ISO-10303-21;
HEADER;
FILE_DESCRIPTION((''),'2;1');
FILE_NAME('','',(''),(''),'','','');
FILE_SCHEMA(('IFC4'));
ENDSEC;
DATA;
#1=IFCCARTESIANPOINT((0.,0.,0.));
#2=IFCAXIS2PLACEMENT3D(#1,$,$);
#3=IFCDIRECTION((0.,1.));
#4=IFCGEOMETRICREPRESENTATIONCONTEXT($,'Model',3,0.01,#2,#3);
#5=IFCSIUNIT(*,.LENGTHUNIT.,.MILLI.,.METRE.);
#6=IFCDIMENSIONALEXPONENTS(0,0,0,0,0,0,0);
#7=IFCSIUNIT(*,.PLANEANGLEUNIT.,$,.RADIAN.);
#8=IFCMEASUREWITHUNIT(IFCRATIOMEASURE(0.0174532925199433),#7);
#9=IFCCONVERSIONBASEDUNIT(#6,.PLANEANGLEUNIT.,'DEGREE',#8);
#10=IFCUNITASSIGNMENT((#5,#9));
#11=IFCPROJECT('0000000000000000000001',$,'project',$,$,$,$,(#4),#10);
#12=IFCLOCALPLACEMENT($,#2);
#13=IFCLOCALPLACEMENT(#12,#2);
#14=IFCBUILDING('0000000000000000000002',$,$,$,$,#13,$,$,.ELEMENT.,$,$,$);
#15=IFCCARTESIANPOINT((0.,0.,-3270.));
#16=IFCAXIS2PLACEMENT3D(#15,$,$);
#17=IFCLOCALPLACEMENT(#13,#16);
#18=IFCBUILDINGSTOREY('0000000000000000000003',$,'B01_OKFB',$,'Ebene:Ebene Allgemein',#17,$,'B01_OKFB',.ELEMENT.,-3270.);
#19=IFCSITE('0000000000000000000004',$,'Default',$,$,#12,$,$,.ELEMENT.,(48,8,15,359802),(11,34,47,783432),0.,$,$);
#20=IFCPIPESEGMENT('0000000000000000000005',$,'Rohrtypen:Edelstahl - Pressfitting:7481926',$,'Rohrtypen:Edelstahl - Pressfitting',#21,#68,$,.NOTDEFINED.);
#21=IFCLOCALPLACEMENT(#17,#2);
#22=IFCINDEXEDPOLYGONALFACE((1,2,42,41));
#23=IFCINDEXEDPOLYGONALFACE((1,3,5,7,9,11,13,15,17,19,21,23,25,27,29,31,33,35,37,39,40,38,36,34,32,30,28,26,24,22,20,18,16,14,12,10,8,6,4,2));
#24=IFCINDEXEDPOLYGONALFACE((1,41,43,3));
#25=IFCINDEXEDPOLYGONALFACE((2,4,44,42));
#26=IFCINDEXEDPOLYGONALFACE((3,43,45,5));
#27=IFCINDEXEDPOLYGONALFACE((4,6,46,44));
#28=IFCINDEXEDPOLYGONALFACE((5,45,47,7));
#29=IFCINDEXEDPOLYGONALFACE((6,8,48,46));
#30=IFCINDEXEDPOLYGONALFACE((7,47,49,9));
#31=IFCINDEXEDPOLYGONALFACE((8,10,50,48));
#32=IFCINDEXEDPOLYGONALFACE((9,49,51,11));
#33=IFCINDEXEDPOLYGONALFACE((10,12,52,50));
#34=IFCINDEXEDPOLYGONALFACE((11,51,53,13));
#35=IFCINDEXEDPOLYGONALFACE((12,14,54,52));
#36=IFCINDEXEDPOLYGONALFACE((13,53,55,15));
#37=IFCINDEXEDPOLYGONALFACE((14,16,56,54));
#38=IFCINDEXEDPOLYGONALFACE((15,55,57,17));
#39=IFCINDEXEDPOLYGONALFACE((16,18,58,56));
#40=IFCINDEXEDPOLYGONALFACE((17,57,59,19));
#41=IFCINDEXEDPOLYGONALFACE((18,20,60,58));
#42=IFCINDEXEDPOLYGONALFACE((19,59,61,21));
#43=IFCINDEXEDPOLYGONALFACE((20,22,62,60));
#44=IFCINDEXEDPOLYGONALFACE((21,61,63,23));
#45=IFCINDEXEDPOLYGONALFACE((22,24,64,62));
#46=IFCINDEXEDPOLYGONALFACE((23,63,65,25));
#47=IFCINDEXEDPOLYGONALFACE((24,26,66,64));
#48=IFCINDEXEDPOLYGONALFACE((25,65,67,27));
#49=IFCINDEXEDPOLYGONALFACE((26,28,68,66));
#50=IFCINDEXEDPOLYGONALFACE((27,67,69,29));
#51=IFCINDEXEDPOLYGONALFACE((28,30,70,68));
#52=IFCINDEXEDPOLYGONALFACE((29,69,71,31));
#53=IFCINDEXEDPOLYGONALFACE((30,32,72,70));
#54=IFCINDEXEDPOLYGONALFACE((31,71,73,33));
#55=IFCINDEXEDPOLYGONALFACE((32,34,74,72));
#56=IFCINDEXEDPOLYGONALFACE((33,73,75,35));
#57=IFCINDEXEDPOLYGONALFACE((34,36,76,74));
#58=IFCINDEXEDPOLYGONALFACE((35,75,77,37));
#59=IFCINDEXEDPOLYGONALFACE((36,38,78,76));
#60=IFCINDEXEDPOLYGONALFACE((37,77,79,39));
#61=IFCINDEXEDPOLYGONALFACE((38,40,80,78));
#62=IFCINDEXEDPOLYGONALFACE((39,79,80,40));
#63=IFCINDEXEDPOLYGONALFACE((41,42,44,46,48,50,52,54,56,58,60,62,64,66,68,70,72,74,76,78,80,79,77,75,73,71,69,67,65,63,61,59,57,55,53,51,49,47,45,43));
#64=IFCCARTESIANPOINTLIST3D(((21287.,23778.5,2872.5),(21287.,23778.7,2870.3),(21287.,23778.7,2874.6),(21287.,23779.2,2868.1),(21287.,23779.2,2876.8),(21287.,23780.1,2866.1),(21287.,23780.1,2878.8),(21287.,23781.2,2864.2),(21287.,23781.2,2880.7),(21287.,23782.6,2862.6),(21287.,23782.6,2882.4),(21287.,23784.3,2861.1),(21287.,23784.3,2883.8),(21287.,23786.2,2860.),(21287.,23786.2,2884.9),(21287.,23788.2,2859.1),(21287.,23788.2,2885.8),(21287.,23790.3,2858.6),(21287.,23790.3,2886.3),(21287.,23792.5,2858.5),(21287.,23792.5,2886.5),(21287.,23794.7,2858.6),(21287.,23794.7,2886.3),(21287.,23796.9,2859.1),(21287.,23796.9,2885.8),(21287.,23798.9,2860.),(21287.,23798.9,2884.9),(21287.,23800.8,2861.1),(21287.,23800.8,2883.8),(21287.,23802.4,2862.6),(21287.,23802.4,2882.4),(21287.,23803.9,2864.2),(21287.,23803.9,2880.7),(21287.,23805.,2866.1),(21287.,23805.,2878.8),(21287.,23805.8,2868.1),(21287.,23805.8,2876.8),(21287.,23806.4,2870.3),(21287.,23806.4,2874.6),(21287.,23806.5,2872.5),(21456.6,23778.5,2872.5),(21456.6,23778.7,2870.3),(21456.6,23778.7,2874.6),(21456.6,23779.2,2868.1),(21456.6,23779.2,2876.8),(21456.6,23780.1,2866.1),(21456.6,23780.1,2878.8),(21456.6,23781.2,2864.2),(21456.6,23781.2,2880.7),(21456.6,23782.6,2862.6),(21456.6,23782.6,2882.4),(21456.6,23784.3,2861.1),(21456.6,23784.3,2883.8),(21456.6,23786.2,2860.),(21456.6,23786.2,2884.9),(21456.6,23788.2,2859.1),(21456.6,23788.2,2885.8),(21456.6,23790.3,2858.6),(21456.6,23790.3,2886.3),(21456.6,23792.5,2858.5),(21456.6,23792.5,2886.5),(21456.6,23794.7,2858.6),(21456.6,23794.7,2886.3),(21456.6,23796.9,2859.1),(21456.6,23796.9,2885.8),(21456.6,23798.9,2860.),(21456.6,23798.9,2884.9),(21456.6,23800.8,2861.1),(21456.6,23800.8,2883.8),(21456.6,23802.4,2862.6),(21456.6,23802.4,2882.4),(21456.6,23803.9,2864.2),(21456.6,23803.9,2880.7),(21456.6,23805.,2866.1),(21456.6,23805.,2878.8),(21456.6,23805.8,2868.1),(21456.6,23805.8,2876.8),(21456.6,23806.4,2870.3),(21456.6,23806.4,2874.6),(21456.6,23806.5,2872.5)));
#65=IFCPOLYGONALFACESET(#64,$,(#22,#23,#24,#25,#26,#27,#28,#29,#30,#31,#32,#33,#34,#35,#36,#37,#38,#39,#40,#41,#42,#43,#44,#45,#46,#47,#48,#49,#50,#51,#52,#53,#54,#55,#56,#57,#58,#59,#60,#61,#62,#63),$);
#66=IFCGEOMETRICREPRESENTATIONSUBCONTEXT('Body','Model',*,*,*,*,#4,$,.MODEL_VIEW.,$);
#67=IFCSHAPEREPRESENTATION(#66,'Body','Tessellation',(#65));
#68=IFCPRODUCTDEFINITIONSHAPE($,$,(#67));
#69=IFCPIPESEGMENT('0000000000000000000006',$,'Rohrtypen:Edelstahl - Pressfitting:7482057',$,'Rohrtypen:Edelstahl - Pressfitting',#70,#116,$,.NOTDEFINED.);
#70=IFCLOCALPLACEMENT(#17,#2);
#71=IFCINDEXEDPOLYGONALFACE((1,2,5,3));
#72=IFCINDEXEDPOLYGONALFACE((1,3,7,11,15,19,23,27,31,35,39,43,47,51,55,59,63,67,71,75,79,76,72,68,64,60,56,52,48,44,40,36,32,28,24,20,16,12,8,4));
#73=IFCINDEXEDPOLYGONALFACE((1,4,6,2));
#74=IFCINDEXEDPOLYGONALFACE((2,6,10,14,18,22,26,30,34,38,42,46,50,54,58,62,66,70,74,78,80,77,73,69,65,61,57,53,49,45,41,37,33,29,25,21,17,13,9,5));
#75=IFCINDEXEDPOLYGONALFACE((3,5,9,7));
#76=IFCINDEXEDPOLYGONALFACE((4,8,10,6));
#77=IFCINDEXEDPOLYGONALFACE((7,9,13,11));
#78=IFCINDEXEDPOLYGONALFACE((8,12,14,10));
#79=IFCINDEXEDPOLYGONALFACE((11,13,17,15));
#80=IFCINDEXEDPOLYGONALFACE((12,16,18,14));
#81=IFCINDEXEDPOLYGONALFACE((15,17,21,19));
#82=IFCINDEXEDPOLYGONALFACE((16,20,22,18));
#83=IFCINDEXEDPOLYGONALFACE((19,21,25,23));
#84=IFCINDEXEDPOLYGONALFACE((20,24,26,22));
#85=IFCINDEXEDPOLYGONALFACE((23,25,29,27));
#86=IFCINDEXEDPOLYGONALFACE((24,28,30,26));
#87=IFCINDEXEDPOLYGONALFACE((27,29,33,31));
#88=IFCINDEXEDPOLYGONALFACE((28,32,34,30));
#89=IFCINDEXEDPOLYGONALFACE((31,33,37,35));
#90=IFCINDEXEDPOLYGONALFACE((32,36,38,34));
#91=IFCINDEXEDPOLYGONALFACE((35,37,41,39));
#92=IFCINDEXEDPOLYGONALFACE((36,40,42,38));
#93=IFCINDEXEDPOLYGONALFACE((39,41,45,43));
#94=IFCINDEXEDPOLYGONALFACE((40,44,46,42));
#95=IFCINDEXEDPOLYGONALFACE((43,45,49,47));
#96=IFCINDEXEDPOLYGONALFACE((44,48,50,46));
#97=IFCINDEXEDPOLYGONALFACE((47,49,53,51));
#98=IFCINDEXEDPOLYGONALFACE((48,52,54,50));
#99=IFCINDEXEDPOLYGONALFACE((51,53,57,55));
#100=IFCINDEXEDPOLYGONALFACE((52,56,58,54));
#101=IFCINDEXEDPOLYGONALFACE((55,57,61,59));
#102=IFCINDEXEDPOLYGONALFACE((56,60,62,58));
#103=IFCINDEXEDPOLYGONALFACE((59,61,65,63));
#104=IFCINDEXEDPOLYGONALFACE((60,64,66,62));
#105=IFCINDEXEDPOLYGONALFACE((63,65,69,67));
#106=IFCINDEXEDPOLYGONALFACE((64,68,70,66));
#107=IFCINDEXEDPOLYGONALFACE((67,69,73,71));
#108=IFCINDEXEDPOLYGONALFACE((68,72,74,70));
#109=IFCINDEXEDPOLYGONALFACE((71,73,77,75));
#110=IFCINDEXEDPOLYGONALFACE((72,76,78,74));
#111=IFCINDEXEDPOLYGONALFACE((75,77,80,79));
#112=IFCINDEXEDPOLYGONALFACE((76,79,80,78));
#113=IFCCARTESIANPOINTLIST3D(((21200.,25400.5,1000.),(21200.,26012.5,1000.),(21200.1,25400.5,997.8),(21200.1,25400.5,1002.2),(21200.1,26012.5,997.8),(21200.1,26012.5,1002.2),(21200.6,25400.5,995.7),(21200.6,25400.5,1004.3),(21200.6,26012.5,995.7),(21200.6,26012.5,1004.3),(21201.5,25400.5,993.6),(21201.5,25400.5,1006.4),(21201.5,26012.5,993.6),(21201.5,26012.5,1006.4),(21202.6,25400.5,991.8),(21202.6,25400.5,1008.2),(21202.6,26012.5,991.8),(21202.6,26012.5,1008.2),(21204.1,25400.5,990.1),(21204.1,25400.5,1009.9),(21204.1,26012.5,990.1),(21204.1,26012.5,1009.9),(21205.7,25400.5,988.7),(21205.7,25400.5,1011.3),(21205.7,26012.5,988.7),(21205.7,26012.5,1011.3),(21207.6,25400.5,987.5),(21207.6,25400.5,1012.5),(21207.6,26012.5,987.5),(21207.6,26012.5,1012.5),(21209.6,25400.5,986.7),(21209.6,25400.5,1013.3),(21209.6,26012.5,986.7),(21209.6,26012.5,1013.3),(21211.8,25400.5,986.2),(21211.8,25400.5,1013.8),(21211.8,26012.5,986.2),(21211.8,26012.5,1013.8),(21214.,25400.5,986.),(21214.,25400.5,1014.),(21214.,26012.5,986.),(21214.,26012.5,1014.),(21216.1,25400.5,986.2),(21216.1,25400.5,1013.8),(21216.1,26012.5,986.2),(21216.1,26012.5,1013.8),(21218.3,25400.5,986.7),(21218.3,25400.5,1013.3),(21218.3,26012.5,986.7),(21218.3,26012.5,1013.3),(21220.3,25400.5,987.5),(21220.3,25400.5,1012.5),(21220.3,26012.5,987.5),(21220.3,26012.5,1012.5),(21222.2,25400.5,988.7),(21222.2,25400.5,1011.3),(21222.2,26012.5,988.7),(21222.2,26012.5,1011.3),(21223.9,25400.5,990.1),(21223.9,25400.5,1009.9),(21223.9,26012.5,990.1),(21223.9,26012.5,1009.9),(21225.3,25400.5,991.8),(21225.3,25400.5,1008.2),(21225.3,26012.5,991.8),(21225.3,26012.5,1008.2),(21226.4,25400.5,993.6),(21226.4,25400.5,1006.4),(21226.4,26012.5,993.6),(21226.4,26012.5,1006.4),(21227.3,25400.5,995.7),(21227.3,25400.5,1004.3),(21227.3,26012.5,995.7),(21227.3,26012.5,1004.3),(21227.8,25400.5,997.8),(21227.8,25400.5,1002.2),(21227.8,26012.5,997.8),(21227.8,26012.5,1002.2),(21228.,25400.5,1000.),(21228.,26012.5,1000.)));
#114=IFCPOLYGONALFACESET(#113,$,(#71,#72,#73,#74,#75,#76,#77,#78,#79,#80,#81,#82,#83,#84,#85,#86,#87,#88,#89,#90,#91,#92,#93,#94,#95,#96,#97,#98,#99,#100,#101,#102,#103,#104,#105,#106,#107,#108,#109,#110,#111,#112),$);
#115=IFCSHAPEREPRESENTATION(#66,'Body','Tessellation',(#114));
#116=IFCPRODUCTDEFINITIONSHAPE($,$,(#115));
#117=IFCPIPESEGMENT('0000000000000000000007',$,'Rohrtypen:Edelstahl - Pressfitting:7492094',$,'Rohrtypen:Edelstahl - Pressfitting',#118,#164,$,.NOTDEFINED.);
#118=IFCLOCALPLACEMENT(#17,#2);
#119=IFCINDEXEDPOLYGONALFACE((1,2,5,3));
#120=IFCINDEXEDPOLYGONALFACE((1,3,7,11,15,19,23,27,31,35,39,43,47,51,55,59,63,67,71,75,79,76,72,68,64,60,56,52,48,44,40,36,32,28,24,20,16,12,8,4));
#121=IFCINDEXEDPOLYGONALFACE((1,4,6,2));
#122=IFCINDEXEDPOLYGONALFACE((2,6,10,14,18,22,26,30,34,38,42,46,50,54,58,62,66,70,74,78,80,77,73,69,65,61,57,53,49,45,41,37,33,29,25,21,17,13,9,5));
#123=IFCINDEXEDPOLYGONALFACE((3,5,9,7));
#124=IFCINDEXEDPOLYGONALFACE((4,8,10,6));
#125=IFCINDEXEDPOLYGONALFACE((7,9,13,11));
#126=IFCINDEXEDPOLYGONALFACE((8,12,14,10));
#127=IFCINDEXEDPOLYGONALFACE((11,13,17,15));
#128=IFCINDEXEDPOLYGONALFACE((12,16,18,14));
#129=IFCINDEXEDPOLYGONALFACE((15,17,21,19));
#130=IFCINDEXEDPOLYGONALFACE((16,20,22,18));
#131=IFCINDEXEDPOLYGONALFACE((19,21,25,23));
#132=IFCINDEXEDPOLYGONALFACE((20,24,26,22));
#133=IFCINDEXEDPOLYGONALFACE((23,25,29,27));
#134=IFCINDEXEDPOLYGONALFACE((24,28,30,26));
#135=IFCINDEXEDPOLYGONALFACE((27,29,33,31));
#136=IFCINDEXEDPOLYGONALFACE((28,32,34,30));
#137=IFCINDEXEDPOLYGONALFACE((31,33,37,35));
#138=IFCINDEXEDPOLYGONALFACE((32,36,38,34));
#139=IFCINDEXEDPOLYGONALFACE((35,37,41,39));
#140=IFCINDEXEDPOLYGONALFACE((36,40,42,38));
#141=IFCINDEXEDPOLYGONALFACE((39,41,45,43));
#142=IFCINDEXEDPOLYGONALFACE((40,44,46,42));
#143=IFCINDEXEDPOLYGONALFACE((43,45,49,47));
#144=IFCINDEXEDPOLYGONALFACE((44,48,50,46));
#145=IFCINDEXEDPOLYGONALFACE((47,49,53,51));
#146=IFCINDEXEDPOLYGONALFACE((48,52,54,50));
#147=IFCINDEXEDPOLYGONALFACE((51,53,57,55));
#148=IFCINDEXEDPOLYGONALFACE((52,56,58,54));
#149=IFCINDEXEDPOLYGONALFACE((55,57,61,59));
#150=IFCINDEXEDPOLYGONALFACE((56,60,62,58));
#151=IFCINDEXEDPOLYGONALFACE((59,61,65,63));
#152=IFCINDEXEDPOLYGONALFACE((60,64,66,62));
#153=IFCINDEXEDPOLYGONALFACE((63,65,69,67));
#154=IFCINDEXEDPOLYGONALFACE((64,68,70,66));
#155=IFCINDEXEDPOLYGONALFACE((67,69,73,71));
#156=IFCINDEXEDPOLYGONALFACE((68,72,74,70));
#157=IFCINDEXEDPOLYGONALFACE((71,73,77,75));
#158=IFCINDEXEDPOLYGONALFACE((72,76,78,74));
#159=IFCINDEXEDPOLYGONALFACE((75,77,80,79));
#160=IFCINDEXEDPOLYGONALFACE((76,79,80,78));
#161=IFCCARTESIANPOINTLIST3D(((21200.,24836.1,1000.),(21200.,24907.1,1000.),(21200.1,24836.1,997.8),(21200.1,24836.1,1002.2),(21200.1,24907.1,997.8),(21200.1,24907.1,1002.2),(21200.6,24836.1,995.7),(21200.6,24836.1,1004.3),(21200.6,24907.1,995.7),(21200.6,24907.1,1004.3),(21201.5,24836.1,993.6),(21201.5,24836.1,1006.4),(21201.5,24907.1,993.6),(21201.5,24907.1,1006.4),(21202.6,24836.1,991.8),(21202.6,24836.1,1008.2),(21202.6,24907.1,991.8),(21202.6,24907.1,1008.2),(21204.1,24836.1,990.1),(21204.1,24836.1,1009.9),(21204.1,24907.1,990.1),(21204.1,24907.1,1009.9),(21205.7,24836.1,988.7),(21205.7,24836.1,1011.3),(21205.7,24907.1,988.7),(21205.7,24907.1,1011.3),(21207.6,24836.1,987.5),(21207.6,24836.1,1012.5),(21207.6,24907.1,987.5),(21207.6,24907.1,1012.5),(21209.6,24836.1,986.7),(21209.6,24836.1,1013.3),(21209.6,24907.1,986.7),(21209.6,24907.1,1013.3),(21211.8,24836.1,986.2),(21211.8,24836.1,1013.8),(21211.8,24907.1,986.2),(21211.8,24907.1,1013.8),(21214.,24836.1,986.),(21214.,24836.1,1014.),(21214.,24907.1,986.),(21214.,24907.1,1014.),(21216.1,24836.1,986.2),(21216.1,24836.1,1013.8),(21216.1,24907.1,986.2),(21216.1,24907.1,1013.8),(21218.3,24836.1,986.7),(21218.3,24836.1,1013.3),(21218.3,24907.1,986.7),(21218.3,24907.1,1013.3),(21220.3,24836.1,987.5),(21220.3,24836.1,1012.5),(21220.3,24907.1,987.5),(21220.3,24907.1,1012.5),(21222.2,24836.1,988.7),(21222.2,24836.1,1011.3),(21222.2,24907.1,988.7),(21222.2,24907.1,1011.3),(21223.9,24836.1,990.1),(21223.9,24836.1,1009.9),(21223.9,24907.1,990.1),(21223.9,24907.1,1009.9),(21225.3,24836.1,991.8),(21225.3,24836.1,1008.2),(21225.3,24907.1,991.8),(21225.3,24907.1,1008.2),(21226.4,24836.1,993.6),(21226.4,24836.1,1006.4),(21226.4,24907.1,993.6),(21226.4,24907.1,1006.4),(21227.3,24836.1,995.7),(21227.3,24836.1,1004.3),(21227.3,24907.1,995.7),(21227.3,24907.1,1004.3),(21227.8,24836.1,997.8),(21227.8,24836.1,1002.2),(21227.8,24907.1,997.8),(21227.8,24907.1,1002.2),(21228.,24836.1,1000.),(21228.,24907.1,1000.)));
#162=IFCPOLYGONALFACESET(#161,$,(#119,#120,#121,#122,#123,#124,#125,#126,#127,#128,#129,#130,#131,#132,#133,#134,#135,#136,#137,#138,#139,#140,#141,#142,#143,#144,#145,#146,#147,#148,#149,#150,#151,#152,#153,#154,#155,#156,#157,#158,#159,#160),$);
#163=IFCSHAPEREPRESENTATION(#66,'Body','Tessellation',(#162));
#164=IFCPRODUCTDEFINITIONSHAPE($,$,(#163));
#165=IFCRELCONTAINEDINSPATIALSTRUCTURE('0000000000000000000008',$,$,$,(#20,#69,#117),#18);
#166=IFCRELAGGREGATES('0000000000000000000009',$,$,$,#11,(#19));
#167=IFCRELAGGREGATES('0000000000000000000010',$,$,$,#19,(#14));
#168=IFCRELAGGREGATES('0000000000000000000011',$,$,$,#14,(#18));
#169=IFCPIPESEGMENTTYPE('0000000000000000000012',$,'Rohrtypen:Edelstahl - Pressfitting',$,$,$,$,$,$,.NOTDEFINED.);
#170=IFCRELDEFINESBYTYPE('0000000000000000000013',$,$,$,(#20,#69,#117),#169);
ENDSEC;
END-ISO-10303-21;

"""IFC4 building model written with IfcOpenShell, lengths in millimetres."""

from ifc_helpers import new_model, entity, si_unit, converted_unit, direction, frame, origin, place, context, subcontext, project, spatial, indexed_curve, outline, extrude, type_object, element, save


model = new_model("IFC4")

# Units and contexts
model_context = context("Model", 3, precision=0.01, world=origin(), true_north=direction((0.0, 1.0)))
body_context = subcontext(model_context, "Body", "Model", "MODEL_VIEW")
ifc_project = project(units=[si_unit("LENGTHUNIT", "METRE", prefix="MILLI"), converted_unit("PLANEANGLEUNIT", "DEGREE", entity("IfcRatioMeasure", 0.0174532925199433), si_unit("PLANEANGLEUNIT", "RADIAN"), dimensions=[0, 0, 0, 0, 0, 0, 0])], contexts=[model_context])

# Site, building, storey
site_placement = place(None, origin())
site = spatial("IfcSite", under=ifc_project, at=site_placement, Name="Default", CompositionType="ELEMENT", RefLatitude=(48, 8, 15, 359802), RefLongitude=(11, 34, 47, 783432), RefElevation=0.0)
building_placement = place(site_placement, origin())
building = spatial("IfcBuilding", under=site, at=building_placement, CompositionType="ELEMENT")
storey_placement = place(building_placement, frame((0.0, 0.0, -3270.0)))
storey = spatial("IfcBuildingStorey", under=building, at=storey_placement, Name="B01_OKFB", ObjectType="Ebene:Ebene Allgemein", LongName="B01_OKFB", CompositionType="ELEMENT", Elevation=-3270.0)

# Pipe segments
pipe_segment_type_1 = type_object("IfcPipeSegmentType", Name="Rohrtypen:Edelstahl - Pressfitting", PredefinedType="NOTDEFINED")
pipe_segment_1_placement = place(storey_placement, origin())
element("IfcPipeSegment", 1, at=pipe_segment_1_placement, inside=storey, type_object=pipe_segment_type_1, Name="Rohrtypen:Edelstahl - Pressfitting:7481926", ObjectType="Rohrtypen:Edelstahl - Pressfitting", PredefinedType="NOTDEFINED", context=body_context, shape_type="SweptSolid", body=[
    extrude(outline(indexed_curve([(14.0, 0.0), (13.8, 2.2), (13.3, 4.3), (12.5, 6.4), (11.3, 8.2), (9.9, 9.9), (8.2, 11.3), (6.4, 12.5), (4.3, 13.3), (2.2, 13.8), (0.0, 14.0), (-2.2, 13.8), (-4.3, 13.3), (-6.4, 12.5), (-8.2, 11.3), (-9.9, 9.9), (-11.3, 8.2), (-12.5, 6.4), (-13.3, 4.3), (-13.8, 2.2), (-14.0, 0.0), (-13.8, -2.2), (-13.3, -4.3), (-12.5, -6.4), (-11.3, -8.2), (-9.9, -9.9), (-8.2, -11.3), (-6.4, -12.5), (-4.3, -13.3), (-2.2, -13.8), (0.0, -14.0), (2.2, -13.8), (4.3, -13.3), (6.4, -12.5), (8.2, -11.3), (9.9, -9.9), (11.3, -8.2), (12.5, -6.4), (13.3, -4.3), (13.8, -2.2), (14.0, 0.0)], self_intersect=False)), frame((21287.0, 23792.5, 2872.5), z_axis=(1.0, 0.0, 0.0), x_axis=(0.0, 1.0, 0.0)), (0.0, 0.0, 1.0), 169.6),
])
pipe_segment_2_placement = place(storey_placement, origin())
element("IfcPipeSegment", 2, at=pipe_segment_2_placement, inside=storey, type_object=pipe_segment_type_1, Name="Rohrtypen:Edelstahl - Pressfitting:7482057", ObjectType="Rohrtypen:Edelstahl - Pressfitting", PredefinedType="NOTDEFINED", context=body_context, shape_type="SweptSolid", body=[
    extrude(outline(indexed_curve([(14.0, 0.0), (13.8, 2.2), (13.3, 4.3), (12.5, 6.4), (11.3, 8.2), (9.9, 9.9), (8.2, 11.3), (6.4, 12.5), (4.3, 13.3), (2.2, 13.8), (0.0, 14.0), (-2.2, 13.8), (-4.3, 13.3), (-6.4, 12.5), (-8.2, 11.3), (-9.9, 9.9), (-11.3, 8.2), (-12.5, 6.4), (-13.3, 4.3), (-13.8, 2.2), (-14.0, 0.0), (-13.8, -2.2), (-13.3, -4.3), (-12.5, -6.4), (-11.3, -8.2), (-9.9, -9.9), (-8.2, -11.3), (-6.4, -12.5), (-4.3, -13.3), (-2.2, -13.8), (0.0, -14.0), (2.2, -13.8), (4.3, -13.3), (6.4, -12.5), (8.2, -11.3), (9.9, -9.9), (11.3, -8.2), (12.5, -6.4), (13.3, -4.3), (13.8, -2.2), (14.0, 0.0)], self_intersect=False)), frame((21214.0, 25400.5, 1000.0), z_axis=(0.0, 1.0, 0.0), x_axis=(1.0, 0.0, 0.0)), (0.0, 0.0, 1.0), 612.0),
])
pipe_segment_3_placement = place(storey_placement, origin())
element("IfcPipeSegment", 3, at=pipe_segment_3_placement, inside=storey, type_object=pipe_segment_type_1, Name="Rohrtypen:Edelstahl - Pressfitting:7492094", ObjectType="Rohrtypen:Edelstahl - Pressfitting", PredefinedType="NOTDEFINED", context=body_context, shape_type="SweptSolid", body=[
    extrude(outline(indexed_curve([(14.0, 0.0), (13.8, 2.2), (13.3, 4.3), (12.5, 6.4), (11.3, 8.2), (9.9, 9.9), (8.2, 11.3), (6.4, 12.5), (4.3, 13.3), (2.2, 13.8), (0.0, 14.0), (-2.2, 13.8), (-4.3, 13.3), (-6.4, 12.5), (-8.2, 11.3), (-9.9, 9.9), (-11.3, 8.2), (-12.5, 6.4), (-13.3, 4.3), (-13.8, 2.2), (-14.0, 0.0), (-13.8, -2.2), (-13.3, -4.3), (-12.5, -6.4), (-11.3, -8.2), (-9.9, -9.9), (-8.2, -11.3), (-6.4, -12.5), (-4.3, -13.3), (-2.2, -13.8), (0.0, -14.0), (2.2, -13.8), (4.3, -13.3), (6.4, -12.5), (8.2, -11.3), (9.9, -9.9), (11.3, -8.2), (12.5, -6.4), (13.3, -4.3), (13.8, -2.2), (14.0, 0.0)], self_intersect=False)), frame((21214.0, 24836.1, 1000.0), z_axis=(0.0, 1.0, 0.0), x_axis=(1.0, 0.0, 0.0)), (0.0, 0.0, 1.0), 71.0),
])

save(model, "model.ifc")
